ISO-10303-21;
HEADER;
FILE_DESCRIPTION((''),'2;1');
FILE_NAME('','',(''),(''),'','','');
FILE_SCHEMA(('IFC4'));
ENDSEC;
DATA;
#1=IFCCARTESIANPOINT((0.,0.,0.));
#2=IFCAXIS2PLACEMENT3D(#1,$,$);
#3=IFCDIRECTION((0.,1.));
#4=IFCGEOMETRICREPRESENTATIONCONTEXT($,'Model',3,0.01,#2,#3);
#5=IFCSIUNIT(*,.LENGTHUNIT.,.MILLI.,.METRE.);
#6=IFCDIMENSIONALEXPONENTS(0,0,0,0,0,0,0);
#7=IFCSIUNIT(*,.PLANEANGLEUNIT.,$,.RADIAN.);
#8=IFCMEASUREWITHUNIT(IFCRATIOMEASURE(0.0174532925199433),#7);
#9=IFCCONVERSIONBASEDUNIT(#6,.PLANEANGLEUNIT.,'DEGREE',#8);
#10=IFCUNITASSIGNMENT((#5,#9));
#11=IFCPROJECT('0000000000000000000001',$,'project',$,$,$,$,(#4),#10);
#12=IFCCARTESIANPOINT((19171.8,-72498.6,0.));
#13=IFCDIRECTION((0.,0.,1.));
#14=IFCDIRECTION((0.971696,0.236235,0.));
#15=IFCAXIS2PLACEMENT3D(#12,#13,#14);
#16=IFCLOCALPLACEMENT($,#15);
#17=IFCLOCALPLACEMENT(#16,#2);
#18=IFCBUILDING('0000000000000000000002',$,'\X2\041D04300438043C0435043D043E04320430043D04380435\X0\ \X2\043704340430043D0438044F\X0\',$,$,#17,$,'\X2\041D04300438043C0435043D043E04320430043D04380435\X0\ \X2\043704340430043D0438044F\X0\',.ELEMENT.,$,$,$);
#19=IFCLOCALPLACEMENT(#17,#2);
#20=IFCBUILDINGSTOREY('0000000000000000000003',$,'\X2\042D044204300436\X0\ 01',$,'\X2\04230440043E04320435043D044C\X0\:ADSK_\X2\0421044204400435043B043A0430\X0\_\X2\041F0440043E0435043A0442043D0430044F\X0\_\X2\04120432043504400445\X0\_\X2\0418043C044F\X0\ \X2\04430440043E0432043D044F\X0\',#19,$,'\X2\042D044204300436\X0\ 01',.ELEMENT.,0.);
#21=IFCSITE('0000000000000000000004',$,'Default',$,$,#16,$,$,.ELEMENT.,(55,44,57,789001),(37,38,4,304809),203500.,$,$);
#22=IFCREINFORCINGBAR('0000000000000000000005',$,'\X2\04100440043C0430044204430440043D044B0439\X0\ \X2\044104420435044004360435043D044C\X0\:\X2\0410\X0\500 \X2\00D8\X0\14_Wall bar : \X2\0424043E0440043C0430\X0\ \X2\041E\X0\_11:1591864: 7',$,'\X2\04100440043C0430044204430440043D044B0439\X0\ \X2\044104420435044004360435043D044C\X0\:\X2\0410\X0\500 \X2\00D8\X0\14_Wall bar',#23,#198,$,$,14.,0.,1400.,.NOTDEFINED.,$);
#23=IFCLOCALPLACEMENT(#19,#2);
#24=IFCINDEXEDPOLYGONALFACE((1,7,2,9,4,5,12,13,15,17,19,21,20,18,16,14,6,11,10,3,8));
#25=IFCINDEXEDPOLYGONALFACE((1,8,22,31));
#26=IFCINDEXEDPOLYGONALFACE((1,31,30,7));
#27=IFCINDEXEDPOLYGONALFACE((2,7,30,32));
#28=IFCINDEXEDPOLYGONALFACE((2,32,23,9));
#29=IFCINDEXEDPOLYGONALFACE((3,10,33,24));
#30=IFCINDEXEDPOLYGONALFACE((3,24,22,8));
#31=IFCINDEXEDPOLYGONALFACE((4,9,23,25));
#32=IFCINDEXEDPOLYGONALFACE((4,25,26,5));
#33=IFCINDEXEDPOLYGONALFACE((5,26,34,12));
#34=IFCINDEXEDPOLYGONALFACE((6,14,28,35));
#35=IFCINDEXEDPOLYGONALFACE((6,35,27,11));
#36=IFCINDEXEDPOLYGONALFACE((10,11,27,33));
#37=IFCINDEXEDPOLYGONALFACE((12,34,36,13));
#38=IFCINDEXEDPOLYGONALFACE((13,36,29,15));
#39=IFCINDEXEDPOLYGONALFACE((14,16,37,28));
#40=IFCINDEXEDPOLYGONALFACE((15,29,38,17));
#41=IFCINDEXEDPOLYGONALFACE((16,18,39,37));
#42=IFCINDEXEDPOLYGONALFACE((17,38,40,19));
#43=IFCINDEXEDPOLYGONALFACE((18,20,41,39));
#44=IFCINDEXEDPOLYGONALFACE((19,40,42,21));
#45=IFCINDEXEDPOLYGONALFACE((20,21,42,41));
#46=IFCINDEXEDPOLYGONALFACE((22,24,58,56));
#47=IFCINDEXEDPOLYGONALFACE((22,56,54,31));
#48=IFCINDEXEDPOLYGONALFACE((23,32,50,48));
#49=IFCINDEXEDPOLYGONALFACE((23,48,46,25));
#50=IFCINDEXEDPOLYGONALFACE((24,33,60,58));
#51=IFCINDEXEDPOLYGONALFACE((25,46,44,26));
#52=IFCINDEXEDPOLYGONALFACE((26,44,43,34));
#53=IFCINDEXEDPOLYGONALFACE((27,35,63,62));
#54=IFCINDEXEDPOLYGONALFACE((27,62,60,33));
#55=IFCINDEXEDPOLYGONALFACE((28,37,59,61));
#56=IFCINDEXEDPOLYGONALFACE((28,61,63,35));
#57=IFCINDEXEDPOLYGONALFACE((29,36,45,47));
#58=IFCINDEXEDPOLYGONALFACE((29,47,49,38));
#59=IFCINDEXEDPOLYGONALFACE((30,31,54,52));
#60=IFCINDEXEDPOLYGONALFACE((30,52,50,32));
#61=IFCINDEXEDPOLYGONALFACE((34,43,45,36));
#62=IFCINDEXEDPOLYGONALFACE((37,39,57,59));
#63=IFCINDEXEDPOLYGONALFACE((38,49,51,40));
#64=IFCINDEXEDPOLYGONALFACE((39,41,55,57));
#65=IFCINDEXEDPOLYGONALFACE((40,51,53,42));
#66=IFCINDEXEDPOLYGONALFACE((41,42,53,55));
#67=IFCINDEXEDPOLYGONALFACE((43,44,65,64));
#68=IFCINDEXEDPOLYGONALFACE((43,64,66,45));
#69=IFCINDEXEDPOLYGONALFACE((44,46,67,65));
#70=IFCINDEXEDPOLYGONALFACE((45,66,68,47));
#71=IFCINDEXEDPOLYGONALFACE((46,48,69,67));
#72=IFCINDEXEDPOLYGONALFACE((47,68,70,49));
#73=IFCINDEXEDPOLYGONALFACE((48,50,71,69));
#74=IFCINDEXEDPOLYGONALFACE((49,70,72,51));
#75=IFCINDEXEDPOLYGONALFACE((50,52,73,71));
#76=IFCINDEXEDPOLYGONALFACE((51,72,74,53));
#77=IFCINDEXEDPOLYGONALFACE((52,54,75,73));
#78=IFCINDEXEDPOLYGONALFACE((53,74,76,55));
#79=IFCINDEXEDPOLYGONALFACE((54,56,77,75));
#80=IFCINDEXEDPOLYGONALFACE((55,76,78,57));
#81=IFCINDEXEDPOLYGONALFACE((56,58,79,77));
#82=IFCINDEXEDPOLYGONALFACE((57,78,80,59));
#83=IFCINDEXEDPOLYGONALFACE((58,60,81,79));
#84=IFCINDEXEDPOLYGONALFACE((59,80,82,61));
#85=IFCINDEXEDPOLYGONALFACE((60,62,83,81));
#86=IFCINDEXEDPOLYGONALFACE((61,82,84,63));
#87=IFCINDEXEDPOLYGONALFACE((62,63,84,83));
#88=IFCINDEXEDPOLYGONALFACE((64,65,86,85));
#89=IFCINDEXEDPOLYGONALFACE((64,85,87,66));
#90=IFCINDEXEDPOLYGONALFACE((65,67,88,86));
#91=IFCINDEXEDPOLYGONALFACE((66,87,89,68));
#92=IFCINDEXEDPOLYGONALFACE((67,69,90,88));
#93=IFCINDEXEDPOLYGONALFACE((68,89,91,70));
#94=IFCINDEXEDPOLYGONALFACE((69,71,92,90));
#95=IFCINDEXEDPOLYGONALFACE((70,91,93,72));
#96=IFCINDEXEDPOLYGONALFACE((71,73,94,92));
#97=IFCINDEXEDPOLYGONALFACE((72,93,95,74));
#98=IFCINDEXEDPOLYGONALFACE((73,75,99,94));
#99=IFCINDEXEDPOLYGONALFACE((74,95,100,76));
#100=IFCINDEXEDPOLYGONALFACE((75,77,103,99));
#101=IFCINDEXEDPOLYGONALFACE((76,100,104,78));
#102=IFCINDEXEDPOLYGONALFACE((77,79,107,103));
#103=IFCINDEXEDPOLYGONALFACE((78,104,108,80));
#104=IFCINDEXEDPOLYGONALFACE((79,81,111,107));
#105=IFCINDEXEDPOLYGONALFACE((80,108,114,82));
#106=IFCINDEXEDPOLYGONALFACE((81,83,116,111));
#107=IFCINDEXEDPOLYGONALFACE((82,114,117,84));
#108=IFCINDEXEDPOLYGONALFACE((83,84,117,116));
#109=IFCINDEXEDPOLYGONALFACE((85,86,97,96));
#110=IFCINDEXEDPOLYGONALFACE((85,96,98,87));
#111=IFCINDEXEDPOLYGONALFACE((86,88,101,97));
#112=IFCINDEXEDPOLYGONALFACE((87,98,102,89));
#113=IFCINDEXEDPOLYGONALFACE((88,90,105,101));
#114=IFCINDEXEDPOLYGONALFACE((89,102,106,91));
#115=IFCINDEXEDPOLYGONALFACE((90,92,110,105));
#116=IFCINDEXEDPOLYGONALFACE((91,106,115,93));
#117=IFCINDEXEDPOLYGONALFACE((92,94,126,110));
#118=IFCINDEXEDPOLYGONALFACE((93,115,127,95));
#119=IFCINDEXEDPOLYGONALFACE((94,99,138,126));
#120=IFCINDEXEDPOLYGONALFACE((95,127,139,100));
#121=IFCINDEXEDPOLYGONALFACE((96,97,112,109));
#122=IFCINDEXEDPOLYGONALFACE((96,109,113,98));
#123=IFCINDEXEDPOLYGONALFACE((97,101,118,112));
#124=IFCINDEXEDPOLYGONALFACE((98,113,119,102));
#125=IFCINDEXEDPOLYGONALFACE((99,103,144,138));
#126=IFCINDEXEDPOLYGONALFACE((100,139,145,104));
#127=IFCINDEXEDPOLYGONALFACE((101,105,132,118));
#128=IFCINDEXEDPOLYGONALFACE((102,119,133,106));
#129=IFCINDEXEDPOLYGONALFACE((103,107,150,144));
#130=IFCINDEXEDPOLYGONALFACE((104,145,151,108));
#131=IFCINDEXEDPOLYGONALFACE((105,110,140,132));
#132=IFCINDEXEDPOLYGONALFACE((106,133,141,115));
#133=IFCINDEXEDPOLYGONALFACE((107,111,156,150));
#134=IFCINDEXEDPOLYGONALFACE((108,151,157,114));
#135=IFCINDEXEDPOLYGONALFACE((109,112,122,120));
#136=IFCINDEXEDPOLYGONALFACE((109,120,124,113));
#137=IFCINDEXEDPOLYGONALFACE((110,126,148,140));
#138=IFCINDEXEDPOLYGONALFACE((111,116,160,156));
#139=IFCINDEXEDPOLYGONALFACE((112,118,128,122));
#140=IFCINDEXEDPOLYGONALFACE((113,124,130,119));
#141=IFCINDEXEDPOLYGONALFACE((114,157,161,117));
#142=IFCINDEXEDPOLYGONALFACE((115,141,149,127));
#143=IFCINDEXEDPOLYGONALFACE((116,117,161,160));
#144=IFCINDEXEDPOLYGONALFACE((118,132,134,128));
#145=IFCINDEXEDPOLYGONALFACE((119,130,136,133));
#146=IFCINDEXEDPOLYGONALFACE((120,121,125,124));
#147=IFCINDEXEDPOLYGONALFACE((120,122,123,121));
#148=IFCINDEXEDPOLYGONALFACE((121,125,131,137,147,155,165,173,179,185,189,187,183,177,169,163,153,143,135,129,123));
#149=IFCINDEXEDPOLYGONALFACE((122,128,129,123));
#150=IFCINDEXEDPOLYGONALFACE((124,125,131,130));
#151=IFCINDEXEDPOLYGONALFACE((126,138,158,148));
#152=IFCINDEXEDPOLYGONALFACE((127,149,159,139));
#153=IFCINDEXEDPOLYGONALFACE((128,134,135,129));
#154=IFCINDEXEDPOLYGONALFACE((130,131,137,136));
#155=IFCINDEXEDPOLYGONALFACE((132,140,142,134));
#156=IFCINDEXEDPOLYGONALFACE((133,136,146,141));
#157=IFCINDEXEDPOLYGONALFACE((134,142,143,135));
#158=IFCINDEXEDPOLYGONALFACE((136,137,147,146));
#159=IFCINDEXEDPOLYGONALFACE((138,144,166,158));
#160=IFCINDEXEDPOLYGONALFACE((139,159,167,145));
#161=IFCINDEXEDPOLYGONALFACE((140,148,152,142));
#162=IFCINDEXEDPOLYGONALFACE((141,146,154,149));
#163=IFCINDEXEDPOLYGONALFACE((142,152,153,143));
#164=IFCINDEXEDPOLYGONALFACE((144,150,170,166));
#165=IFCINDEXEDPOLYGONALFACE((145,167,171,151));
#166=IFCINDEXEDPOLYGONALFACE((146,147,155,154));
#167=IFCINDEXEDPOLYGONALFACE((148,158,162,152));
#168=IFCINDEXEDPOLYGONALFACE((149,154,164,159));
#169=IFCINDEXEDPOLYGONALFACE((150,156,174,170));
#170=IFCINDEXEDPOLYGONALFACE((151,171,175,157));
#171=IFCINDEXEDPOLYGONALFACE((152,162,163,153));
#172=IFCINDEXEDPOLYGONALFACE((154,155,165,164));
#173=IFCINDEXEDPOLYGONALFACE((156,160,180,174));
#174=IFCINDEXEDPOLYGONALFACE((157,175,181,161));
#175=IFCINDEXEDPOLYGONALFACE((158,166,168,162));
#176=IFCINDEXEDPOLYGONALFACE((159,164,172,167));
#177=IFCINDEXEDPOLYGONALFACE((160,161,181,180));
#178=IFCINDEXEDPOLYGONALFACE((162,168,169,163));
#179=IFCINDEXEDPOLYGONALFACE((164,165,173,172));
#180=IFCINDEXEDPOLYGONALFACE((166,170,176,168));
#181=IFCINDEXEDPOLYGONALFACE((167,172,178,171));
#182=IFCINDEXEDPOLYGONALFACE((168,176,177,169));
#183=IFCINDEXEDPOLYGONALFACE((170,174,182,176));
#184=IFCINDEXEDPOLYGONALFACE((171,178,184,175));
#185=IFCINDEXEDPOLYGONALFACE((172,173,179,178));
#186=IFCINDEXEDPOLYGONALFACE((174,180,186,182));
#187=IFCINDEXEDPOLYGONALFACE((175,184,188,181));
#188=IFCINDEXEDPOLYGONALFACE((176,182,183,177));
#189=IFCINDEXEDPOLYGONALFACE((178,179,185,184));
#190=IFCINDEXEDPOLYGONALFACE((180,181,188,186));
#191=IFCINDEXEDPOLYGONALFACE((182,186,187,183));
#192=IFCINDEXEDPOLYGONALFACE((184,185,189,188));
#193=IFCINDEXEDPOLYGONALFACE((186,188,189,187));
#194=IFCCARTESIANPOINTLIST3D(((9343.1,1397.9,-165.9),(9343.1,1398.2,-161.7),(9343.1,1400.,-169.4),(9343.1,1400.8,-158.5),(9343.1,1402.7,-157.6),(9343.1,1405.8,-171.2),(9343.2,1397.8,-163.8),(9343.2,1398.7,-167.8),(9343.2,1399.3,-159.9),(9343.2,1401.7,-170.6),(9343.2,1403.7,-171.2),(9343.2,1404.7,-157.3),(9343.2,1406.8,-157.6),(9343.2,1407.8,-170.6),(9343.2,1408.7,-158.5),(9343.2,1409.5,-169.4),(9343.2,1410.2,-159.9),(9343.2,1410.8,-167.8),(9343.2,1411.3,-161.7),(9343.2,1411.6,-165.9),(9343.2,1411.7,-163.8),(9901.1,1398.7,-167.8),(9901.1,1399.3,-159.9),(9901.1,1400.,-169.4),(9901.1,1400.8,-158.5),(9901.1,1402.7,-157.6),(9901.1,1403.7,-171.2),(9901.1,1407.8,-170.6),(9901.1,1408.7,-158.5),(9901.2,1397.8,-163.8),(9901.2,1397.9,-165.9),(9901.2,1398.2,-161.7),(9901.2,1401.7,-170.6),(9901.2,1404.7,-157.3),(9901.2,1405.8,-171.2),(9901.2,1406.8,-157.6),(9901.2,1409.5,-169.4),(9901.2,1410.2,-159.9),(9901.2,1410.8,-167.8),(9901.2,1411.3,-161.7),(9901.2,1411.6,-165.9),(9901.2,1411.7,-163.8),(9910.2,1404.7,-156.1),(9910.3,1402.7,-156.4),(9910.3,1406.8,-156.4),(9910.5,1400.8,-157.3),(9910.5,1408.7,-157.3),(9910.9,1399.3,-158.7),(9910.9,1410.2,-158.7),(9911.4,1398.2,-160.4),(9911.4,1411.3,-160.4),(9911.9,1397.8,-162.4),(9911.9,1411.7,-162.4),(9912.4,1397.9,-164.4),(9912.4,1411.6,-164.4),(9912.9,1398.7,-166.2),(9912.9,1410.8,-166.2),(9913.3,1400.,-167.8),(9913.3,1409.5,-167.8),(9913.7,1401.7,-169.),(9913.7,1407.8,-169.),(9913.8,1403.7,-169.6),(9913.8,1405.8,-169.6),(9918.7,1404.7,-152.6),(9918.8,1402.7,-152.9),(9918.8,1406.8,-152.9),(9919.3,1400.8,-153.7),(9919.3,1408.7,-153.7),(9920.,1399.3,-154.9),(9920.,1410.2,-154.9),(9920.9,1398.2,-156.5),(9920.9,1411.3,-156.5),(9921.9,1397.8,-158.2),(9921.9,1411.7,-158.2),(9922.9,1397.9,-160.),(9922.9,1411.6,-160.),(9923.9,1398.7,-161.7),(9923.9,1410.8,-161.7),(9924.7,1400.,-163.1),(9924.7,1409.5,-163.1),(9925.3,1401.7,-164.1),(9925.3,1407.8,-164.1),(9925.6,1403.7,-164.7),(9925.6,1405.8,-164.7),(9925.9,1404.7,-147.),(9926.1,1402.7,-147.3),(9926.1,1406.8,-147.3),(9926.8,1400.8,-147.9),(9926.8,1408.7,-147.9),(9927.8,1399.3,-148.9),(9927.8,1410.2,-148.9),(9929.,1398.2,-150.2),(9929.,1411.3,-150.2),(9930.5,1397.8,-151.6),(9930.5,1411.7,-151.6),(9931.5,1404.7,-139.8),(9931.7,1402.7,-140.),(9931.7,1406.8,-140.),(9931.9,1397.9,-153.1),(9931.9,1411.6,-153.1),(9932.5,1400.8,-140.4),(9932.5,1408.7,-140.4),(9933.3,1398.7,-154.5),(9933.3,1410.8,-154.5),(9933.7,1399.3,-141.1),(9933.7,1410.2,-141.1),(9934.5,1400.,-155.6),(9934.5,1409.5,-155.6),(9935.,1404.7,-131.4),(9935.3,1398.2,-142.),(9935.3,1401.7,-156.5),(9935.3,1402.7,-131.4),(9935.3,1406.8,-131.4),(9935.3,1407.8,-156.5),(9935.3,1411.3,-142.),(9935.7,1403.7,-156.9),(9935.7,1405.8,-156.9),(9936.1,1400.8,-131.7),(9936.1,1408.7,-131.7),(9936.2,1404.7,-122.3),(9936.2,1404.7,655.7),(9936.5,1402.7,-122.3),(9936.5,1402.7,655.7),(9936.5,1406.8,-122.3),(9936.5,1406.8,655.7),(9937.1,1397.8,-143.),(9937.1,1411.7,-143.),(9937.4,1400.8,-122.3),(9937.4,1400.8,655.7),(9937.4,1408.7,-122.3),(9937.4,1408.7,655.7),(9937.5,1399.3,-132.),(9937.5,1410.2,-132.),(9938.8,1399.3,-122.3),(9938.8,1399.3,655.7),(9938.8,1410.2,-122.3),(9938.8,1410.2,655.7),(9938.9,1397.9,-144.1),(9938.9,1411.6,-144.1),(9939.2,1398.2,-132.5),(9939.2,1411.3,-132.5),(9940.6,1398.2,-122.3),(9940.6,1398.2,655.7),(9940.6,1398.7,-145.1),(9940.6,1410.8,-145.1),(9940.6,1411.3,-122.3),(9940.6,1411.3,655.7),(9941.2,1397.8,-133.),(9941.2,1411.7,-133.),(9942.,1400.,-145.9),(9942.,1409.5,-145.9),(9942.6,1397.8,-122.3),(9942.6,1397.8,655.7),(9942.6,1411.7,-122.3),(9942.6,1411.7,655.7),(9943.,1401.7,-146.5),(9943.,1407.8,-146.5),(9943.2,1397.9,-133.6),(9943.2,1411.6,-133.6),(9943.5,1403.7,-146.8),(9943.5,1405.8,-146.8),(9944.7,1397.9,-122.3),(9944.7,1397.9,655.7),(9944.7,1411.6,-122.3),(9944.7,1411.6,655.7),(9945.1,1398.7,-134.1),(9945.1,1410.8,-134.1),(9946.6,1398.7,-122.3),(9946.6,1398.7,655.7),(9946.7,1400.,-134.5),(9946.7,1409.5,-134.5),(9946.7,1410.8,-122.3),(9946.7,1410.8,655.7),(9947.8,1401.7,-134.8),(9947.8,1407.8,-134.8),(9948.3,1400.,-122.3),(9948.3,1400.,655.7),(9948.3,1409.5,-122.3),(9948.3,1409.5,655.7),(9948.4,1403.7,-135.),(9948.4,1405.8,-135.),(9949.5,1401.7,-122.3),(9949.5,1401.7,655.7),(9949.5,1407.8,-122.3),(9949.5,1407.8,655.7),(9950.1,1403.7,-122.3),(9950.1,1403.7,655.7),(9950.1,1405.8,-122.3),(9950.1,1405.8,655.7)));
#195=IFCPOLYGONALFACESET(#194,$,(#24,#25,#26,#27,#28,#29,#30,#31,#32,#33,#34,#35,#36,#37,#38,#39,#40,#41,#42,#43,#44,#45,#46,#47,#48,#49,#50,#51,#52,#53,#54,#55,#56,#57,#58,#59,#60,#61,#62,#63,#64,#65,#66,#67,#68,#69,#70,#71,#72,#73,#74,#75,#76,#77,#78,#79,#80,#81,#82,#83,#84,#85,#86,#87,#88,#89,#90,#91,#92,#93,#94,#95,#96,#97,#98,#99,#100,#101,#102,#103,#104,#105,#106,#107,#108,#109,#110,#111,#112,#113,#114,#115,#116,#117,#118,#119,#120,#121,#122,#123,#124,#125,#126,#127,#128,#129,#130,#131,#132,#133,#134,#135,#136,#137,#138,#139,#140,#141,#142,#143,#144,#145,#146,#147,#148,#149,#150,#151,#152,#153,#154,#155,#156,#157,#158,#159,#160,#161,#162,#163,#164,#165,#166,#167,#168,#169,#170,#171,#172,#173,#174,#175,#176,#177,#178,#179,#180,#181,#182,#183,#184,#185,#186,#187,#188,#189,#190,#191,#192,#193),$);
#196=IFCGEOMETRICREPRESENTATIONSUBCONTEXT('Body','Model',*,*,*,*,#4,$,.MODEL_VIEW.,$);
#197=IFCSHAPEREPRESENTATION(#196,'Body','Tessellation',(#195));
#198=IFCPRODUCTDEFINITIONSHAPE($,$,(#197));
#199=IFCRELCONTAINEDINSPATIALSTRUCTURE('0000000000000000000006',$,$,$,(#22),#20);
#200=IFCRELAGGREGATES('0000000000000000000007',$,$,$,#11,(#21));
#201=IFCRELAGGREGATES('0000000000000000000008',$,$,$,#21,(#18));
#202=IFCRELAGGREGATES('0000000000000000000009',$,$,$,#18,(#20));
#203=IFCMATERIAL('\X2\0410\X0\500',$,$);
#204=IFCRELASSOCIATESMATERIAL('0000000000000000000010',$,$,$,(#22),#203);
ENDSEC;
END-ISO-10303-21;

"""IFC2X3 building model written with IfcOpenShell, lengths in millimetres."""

from ifc_helpers import new_model, entity, si_unit, converted_unit, direction, frame, origin, place, context, subcontext, project, spatial, material, element, save


model = new_model("IFC2X3")

# Units and contexts
model_context = context("Model", 3, precision=0.01, world=origin(), true_north=direction((0.0, 1.0)))
body_context = subcontext(model_context, "Body", "Model", "MODEL_VIEW")
ifc_project = project(units=[si_unit("LENGTHUNIT", "METRE", prefix="MILLI"), converted_unit("PLANEANGLEUNIT", "DEGREE", entity("IfcRatioMeasure", 0.0174532925199433), si_unit("PLANEANGLEUNIT", "RADIAN"), dimensions=[0, 0, 0, 0, 0, 0, 0])], contexts=[model_context])

# Site, building, storey
site_placement = place(None, frame((19171.8, -72498.6, 0.0), z_axis=(0.0, 0.0, 1.0), x_axis=(0.971696, 0.236235, 0.0)))
site = spatial("IfcSite", under=ifc_project, at=site_placement, Name="Default", CompositionType="ELEMENT", RefLatitude=(55, 44, 57, 789001), RefLongitude=(37, 38, 4, 304809), RefElevation=203500.0)
building_placement = place(site_placement, origin())
building = spatial("IfcBuilding", under=site, at=building_placement, Name="Наименование здания", LongName="Наименование здания", CompositionType="ELEMENT")
storey_placement = place(building_placement, origin())
storey = spatial("IfcBuildingStorey", under=building, at=storey_placement, Name="Этаж 01", ObjectType="Уровень:ADSK_Стрелка_Проектная_Вверх_Имя уровня", LongName="Этаж 01", CompositionType="ELEMENT", Elevation=0.0)

# Reinforcing bar
ifc_material = material(Name="А500")
placement = place(storey_placement, origin())
element("IfcReinforcingBar", 1, at=placement, inside=storey, material=ifc_material, Name="Арматурный стержень:А500 Ø14_Wall bar : Форма О_11:1591864: 7", ObjectType="Арматурный стержень:А500 Ø14_Wall bar", BarLength=1400.0, BarRole="NOTDEFINED", CrossSectionArea=0.0, NominalDiameter=14.0, context=body_context, shape_type="AdvancedSweptSolid", body=[
    entity("IfcSweptDiskSolid", entity("IfcCompositeCurve", [entity("IfcCompositeCurveSegment", "CONTINUOUS", True, entity("IfcPolyline", [entity("IfcCartesianPoint", [9943.1, 1404.7, 655.7]), entity("IfcCartesianPoint", [9943.1, 1404.7, -122.3])])), entity("IfcCompositeCurveSegment", "CONTINUOUS", True, entity("IfcTrimmedCurve", entity("IfcCircle", entity("IfcAxis2Placement3D", entity("IfcCartesianPoint", [9901.1, 1404.7, -122.3]), entity("IfcDirection", [0.0, 1.0, 0.0]), entity("IfcDirection", [0.0, 0.0, -1.0])), 42.0), [entity("IfcParameterValue", 270.0)], [entity("IfcParameterValue", 360.0)], True, "PARAMETER")), entity("IfcCompositeCurveSegment", "CONTINUOUS", True, entity("IfcPolyline", [entity("IfcCartesianPoint", [9901.1, 1404.7, -164.3]), entity("IfcCartesianPoint", [9343.1, 1404.7, -164.3])]))], False), 7.0, None, 0.0, 92.0),
])

save(model, "model.ifc")
